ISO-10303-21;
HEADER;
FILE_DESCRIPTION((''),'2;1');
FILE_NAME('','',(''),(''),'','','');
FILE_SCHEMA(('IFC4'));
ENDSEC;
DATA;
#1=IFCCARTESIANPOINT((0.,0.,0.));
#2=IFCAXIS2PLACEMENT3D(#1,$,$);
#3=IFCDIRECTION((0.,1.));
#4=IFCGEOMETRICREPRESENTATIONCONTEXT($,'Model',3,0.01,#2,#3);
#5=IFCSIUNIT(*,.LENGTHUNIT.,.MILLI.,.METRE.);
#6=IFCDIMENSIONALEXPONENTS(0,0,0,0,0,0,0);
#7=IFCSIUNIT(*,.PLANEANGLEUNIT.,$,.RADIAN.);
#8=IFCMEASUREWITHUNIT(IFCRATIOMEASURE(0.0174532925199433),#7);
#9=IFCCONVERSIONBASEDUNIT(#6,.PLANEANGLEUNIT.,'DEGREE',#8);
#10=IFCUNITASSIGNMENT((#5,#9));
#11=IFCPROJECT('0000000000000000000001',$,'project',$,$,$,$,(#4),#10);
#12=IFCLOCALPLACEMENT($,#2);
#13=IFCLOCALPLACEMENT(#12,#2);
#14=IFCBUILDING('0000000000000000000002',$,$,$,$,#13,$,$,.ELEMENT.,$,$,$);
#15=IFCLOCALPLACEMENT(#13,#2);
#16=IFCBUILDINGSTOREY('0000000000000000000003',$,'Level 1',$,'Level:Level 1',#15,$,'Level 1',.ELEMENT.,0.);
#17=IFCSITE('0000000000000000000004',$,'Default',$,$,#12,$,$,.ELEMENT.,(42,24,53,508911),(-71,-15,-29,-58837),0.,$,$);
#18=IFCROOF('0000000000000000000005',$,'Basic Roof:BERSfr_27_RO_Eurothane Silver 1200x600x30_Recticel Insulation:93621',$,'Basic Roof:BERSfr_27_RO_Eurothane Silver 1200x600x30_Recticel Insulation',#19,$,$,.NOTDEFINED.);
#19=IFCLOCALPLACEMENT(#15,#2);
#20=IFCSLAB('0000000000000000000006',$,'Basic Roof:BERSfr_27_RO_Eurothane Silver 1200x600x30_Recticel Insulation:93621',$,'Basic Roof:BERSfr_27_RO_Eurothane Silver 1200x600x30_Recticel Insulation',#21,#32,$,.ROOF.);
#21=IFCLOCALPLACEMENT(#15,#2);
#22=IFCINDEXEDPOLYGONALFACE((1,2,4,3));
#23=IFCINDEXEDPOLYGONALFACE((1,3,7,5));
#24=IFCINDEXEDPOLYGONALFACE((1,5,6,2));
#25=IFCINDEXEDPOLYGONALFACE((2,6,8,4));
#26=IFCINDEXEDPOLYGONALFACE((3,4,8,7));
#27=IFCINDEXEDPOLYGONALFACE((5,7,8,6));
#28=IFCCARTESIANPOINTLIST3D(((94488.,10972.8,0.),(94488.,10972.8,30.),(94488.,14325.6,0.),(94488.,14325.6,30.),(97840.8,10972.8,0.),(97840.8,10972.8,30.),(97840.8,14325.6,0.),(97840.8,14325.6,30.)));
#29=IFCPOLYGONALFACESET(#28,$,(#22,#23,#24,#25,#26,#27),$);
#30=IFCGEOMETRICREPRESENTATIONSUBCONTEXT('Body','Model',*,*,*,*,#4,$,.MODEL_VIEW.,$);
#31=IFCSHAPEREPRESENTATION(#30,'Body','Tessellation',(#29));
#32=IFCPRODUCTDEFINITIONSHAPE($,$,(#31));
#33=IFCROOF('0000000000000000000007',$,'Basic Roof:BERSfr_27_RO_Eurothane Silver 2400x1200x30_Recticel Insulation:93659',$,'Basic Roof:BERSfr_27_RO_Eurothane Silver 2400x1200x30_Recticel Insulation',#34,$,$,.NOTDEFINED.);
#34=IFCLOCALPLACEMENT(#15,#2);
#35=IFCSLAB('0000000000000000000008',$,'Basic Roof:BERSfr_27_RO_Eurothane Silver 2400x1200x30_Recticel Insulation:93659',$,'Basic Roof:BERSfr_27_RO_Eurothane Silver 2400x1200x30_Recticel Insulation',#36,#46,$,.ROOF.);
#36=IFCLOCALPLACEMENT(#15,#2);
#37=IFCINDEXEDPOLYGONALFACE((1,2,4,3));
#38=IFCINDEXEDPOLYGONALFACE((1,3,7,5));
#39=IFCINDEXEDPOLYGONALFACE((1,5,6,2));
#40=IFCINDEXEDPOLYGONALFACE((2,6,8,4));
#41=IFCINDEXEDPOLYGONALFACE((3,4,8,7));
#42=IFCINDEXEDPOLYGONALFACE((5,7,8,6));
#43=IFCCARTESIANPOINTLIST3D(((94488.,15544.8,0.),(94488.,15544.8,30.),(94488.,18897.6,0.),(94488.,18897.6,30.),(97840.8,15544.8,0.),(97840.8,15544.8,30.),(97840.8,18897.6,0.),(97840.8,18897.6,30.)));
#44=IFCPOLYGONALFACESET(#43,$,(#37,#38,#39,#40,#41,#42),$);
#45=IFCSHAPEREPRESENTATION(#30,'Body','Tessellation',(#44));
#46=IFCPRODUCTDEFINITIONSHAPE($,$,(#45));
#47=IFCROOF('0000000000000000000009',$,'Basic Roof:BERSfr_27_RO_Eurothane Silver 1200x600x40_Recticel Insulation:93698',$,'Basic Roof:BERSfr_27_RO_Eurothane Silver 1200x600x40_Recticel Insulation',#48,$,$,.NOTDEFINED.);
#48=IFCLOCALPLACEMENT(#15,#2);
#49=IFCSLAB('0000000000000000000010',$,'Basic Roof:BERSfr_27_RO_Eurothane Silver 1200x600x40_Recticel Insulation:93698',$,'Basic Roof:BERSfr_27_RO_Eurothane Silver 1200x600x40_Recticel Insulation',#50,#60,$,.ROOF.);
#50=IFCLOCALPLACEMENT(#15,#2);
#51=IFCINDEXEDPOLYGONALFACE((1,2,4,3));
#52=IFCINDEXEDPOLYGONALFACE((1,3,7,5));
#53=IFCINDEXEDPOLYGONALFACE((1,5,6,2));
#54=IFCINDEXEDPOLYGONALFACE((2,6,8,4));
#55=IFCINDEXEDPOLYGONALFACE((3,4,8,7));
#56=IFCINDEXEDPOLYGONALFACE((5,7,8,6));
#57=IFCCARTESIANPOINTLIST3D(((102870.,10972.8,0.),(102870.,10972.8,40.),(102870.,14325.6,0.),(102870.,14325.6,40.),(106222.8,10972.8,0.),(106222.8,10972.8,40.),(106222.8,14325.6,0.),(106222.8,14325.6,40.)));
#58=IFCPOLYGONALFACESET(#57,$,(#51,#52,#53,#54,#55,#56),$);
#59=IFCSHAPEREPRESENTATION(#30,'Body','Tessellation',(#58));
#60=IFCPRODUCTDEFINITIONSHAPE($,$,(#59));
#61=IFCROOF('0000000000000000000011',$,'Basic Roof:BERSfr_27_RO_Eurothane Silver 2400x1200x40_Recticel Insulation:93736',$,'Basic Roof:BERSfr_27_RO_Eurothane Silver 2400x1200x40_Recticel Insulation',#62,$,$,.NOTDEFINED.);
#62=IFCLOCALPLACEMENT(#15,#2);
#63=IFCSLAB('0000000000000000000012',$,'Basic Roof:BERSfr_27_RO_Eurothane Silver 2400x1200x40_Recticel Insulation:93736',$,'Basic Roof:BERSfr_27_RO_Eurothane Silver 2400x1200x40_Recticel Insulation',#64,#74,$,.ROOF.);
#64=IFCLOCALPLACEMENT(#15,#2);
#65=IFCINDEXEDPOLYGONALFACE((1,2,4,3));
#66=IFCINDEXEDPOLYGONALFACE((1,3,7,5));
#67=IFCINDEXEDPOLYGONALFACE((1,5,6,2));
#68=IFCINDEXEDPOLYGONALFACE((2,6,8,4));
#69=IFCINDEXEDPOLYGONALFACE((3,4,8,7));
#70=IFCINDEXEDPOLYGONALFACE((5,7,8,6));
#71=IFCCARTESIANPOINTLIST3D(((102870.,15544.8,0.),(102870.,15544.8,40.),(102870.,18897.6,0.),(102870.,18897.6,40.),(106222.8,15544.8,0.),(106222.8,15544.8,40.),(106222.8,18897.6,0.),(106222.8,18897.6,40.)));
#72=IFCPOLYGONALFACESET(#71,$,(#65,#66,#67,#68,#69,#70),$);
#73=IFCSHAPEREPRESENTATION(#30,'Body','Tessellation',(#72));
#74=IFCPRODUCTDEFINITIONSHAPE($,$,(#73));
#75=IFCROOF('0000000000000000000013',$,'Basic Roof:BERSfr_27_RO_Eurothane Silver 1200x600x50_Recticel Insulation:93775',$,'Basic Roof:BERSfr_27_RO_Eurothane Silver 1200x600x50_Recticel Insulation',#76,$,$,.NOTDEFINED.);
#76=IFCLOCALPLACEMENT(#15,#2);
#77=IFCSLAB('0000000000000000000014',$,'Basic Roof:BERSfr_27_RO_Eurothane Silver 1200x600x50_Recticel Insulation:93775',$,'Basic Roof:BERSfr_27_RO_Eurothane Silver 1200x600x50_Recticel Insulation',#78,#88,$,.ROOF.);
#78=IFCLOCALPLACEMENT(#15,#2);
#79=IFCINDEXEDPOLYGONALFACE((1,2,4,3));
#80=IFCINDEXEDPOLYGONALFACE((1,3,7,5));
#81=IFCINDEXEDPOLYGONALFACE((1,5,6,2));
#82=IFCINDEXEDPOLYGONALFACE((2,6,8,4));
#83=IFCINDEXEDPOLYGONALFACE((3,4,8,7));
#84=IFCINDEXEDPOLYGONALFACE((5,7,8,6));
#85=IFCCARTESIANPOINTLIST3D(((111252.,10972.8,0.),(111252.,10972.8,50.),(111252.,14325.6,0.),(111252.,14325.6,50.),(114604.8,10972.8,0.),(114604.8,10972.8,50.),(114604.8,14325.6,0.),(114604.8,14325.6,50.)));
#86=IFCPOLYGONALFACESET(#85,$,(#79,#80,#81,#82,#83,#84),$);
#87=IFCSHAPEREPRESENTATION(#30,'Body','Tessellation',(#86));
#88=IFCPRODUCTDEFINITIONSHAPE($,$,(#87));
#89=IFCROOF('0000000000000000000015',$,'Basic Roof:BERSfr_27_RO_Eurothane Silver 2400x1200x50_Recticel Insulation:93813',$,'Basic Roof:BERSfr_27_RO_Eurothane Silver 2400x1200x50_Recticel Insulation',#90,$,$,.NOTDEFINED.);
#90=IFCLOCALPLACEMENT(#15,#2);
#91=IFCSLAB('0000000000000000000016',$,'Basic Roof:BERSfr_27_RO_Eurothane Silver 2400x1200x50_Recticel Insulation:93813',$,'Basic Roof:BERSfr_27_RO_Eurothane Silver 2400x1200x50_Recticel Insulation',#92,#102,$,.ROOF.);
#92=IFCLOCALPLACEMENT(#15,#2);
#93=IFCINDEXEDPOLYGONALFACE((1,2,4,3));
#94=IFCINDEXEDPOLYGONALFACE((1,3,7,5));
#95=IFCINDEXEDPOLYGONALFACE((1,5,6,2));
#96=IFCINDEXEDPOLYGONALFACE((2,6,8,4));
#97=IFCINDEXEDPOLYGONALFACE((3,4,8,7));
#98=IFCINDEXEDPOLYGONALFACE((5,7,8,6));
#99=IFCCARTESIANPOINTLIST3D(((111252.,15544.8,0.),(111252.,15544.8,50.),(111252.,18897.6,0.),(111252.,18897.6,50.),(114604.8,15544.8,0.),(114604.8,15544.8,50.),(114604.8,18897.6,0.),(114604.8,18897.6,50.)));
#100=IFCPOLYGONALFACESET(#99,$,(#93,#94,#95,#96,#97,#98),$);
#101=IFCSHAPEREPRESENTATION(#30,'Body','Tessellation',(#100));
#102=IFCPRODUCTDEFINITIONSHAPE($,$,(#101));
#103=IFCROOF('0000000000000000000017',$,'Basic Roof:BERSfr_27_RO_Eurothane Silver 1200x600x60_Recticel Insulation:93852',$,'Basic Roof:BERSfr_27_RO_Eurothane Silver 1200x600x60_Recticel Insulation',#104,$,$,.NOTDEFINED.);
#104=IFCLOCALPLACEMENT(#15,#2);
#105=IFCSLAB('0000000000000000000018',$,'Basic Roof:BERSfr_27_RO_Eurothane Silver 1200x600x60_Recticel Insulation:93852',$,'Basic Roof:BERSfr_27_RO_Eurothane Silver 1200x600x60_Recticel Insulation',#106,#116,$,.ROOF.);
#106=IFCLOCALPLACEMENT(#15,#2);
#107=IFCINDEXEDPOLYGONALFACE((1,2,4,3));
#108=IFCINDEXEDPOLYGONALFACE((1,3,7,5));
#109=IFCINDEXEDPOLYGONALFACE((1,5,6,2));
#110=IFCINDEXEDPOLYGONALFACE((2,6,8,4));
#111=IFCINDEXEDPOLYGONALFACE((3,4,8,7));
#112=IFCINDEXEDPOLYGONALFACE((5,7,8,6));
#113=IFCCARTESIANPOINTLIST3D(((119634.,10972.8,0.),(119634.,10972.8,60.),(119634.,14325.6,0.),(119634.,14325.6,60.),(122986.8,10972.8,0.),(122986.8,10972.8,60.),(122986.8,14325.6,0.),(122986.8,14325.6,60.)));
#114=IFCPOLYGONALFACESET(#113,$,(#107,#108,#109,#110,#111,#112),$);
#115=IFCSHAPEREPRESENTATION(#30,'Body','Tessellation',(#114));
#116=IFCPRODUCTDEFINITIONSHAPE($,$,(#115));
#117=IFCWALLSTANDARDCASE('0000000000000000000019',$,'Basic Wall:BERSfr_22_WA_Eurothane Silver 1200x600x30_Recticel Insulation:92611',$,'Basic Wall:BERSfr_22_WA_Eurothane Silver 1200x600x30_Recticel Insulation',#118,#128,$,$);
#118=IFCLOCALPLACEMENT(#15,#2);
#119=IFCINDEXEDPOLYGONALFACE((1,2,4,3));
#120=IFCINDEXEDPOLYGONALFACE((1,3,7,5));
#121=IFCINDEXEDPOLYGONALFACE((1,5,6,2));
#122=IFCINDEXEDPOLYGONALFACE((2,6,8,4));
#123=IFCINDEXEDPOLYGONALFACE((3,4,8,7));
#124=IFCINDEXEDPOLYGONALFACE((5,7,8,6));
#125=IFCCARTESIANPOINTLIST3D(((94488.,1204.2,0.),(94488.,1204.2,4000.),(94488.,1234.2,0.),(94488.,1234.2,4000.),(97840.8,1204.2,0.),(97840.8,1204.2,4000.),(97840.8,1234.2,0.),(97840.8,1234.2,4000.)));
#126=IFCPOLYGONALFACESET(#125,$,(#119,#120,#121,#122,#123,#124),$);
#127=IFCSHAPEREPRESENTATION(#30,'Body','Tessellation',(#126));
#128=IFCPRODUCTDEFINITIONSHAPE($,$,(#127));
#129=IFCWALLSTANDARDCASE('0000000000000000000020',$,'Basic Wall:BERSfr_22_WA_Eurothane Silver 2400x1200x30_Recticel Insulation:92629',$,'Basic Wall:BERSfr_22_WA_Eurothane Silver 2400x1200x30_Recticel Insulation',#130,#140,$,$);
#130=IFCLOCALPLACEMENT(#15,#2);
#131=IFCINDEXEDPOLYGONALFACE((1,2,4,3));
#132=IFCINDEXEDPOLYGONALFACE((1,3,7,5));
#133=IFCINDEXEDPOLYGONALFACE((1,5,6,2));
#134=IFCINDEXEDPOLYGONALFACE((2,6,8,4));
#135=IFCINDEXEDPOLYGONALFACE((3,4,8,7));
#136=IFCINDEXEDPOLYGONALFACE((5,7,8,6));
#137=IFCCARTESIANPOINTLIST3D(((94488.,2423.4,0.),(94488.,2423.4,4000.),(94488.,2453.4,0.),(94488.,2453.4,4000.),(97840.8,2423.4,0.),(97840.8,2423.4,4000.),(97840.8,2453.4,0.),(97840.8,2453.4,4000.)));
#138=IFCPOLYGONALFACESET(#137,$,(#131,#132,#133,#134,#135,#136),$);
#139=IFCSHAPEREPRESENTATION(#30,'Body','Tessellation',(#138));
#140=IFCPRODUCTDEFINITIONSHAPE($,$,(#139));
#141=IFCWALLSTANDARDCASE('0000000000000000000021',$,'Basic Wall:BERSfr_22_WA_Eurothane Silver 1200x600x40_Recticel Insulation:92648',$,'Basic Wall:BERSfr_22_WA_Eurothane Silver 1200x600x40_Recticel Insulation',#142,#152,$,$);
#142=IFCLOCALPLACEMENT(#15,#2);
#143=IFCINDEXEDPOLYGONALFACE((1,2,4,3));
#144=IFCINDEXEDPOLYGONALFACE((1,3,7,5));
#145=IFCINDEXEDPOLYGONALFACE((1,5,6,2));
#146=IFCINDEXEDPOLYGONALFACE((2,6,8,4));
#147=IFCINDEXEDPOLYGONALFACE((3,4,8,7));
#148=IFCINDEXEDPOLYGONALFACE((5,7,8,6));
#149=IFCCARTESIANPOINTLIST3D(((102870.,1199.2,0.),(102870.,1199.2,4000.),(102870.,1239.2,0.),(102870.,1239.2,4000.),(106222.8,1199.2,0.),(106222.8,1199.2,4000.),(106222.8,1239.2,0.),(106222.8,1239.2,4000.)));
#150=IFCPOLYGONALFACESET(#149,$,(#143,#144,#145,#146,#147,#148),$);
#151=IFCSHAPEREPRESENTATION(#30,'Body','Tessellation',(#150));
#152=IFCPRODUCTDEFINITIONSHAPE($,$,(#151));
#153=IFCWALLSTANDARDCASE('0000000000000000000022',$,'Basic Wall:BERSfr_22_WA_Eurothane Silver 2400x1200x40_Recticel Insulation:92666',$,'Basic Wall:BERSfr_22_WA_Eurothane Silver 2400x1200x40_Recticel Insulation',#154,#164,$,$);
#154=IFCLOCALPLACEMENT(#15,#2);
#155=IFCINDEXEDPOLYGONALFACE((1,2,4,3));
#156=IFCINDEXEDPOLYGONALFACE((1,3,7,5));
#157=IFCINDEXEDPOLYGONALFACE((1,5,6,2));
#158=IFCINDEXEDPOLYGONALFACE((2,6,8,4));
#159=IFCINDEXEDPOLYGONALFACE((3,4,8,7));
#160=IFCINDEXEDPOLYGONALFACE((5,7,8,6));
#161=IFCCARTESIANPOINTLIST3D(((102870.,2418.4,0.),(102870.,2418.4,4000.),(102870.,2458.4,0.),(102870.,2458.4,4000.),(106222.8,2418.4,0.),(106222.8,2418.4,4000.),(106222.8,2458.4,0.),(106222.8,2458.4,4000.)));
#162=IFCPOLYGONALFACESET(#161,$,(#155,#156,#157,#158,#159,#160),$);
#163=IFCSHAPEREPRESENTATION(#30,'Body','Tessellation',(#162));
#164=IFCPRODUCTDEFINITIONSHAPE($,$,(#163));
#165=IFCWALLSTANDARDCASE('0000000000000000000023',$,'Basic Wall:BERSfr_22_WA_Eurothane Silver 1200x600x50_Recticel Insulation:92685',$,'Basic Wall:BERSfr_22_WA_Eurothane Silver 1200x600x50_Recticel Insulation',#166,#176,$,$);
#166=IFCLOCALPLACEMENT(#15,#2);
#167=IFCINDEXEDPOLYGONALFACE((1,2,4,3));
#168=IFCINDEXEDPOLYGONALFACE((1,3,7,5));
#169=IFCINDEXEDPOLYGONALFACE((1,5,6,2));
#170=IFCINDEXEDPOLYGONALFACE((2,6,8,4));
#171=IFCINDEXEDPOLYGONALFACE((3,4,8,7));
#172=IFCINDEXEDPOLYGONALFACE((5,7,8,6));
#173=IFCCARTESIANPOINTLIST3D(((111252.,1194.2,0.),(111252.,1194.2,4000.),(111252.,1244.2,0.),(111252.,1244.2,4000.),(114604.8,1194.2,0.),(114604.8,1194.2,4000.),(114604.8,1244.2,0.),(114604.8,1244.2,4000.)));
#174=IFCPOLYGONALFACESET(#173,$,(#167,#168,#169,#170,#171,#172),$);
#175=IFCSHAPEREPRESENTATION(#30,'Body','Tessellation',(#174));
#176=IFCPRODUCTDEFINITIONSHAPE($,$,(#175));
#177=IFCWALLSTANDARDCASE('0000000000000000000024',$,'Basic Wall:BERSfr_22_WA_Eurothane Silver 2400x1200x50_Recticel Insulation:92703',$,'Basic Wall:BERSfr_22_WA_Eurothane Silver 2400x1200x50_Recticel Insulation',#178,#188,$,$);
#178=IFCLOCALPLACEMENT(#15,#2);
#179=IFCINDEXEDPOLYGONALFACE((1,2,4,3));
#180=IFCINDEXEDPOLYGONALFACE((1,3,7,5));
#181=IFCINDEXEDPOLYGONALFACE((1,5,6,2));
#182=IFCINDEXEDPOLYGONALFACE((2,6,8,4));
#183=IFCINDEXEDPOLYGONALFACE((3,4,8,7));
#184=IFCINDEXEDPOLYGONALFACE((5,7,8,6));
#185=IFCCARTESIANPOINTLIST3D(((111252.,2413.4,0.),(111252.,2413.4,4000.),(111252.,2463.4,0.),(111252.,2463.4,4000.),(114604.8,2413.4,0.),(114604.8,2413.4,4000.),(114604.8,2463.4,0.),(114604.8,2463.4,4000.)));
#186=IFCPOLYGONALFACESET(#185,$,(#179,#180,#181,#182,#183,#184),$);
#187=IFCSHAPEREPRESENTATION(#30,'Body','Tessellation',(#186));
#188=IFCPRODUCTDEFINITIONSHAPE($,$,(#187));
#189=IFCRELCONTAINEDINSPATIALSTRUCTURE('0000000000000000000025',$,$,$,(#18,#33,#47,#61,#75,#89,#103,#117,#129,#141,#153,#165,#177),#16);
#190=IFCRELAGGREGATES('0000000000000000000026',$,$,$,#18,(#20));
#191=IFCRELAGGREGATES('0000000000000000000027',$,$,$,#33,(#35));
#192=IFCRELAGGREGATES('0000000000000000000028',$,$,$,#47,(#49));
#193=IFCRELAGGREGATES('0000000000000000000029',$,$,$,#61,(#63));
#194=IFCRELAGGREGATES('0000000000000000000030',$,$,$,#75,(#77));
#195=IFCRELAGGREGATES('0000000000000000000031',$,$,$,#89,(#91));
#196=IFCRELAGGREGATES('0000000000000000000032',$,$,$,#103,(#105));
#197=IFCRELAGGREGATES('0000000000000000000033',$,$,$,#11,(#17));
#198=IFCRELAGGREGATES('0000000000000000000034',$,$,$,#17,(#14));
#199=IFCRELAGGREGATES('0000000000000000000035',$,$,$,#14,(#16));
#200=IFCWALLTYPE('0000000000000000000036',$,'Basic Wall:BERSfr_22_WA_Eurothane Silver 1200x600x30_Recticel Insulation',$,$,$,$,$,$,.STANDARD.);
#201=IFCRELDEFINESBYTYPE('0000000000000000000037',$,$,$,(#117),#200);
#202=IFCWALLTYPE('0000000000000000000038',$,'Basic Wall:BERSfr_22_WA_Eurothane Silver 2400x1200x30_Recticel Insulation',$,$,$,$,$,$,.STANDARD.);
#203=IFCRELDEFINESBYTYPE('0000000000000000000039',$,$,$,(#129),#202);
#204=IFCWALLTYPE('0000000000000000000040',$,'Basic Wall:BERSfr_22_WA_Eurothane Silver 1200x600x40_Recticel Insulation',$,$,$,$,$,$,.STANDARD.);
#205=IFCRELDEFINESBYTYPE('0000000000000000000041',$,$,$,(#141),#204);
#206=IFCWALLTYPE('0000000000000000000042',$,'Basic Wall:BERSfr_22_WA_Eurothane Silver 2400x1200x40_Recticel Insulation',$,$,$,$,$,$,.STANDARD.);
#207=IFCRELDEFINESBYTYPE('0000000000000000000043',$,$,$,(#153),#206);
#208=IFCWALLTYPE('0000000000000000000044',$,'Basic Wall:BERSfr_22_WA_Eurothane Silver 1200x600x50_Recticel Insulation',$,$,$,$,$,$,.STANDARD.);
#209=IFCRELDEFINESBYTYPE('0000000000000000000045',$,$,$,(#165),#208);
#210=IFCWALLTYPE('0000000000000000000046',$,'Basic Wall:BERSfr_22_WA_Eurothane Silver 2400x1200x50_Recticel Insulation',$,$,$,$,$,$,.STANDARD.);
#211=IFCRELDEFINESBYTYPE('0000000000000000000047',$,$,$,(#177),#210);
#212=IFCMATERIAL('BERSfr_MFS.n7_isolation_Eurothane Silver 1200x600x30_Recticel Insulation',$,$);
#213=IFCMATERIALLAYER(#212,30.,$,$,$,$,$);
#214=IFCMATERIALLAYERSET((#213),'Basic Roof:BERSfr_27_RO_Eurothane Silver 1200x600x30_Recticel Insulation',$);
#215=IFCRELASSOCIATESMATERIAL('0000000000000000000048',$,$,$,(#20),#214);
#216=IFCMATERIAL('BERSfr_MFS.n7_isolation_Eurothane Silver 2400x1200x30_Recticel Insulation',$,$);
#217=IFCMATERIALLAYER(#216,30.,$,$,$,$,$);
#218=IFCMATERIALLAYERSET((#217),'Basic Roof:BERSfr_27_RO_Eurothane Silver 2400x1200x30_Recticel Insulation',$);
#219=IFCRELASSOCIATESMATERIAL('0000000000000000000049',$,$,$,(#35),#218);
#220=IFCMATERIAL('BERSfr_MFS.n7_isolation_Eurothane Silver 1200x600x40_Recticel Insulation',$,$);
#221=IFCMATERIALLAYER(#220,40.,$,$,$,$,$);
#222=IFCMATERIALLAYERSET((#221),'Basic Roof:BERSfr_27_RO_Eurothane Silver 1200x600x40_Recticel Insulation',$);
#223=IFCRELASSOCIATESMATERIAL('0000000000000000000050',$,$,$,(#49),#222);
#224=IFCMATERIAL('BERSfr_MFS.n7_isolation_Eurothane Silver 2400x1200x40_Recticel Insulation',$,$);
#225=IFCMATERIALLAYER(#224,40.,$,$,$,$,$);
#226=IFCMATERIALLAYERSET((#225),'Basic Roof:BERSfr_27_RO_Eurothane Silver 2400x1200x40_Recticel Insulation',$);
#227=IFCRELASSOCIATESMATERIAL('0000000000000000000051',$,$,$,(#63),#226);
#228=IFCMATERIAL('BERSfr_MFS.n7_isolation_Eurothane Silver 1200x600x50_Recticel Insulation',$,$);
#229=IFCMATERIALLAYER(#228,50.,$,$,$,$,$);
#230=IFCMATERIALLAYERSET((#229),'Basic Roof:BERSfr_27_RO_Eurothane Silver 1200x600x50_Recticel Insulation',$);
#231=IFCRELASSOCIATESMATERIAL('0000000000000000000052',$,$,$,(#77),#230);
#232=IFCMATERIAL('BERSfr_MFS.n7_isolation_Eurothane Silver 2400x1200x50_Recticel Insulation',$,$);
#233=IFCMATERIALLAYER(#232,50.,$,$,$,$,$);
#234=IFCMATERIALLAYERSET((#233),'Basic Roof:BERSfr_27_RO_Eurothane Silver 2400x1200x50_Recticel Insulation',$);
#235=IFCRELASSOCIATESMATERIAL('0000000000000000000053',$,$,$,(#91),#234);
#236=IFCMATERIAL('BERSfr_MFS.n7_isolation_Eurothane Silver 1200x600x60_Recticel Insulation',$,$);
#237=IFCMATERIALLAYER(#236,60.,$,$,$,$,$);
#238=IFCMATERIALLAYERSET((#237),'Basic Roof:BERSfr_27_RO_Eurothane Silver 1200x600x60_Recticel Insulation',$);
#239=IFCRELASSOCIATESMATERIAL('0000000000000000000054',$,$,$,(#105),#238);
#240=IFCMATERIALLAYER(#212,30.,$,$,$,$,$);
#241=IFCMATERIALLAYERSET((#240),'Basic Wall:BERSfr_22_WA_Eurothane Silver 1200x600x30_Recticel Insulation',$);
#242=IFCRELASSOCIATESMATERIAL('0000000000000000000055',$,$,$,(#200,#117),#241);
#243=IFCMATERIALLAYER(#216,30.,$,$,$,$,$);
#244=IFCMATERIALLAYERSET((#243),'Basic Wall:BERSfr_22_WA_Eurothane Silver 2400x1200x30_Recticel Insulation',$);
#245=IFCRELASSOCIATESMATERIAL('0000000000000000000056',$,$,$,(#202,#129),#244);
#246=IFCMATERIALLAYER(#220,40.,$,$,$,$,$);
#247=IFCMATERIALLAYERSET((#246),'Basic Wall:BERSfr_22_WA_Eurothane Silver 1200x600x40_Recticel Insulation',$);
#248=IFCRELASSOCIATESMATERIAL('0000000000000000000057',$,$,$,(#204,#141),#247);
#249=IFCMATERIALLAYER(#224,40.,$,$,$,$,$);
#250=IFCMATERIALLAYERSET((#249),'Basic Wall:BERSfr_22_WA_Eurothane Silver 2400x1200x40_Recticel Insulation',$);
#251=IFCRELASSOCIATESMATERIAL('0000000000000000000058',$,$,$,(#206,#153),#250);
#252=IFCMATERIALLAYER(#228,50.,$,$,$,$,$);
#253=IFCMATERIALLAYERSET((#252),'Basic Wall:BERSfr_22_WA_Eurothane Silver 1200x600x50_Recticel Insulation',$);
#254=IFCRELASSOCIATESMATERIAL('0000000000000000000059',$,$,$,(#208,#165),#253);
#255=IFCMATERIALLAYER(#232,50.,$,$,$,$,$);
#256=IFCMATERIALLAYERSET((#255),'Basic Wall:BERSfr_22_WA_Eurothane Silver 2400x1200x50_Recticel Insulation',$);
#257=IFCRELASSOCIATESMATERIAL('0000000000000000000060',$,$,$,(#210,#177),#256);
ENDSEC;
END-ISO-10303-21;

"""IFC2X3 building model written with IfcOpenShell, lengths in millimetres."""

from ifc_helpers import new_model, entity, si_unit, converted_unit, direction, frame, frame_2d, origin, place, context, subcontext, project, spatial, rectangle, extrude, material, layer, layer_set, layer_usage, type_object, element, aggregate, save


model = new_model("IFC2X3")

# Units and contexts
model_context = context("Model", 3, precision=0.01, world=origin(), true_north=direction((0.0, 1.0)))
body_context = subcontext(model_context, "Body", "Model", "MODEL_VIEW")
ifc_project = project(units=[si_unit("LENGTHUNIT", "METRE", prefix="MILLI"), converted_unit("PLANEANGLEUNIT", "DEGREE", entity("IfcRatioMeasure", 0.0174532925199433), si_unit("PLANEANGLEUNIT", "RADIAN"), dimensions=[0, 0, 0, 0, 0, 0, 0])], contexts=[model_context])

# Site, building, storey
site_placement = place(None, origin())
site = spatial("IfcSite", under=ifc_project, at=site_placement, Name="Default", CompositionType="ELEMENT", RefLatitude=(42, 24, 53, 508911), RefLongitude=(-71, -15, -29, -58837), RefElevation=0.0)
building_placement = place(site_placement, origin())
building = spatial("IfcBuilding", under=site, at=building_placement, CompositionType="ELEMENT")
storey_placement = place(building_placement, origin())
storey = spatial("IfcBuildingStorey", under=building, at=storey_placement, Name="Level 1", ObjectType="Level:Level 1", LongName="Level 1", CompositionType="ELEMENT", Elevation=0.0)

# Roofs, slabs
roof_1_placement = place(storey_placement, frame((94488.0, 10972.8, 0.0)))
roof_1 = element("IfcRoof", 1, at=roof_1_placement, inside=storey, Name="Basic Roof:BERSfr_27_RO_Eurothane Silver 1200x600x30_Recticel Insulation:93621", ObjectType="Basic Roof:BERSfr_27_RO_Eurothane Silver 1200x600x30_Recticel Insulation", ShapeType="NOTDEFINED")
ifc_material_1 = material(Name="BERSfr_MFS.n7_isolation_Eurothane Silver 1200x600x30_Recticel Insulation")
ifc_layer_1 = layer(ifc_material_1, 30.0)
ifc_layer_set_1 = layer_set([ifc_layer_1], Name="Basic Roof:BERSfr_27_RO_Eurothane Silver 1200x600x30_Recticel Insulation")
slab_1_placement = place(roof_1_placement, origin())
slab_1 = element("IfcSlab", 2, at=slab_1_placement, material=ifc_layer_set_1, Name="Basic Roof:BERSfr_27_RO_Eurothane Silver 1200x600x30_Recticel Insulation:93621", ObjectType="Basic Roof:BERSfr_27_RO_Eurothane Silver 1200x600x30_Recticel Insulation", PredefinedType="ROOF", context=body_context, shape_type="SweptSolid", body=[
    extrude(rectangle(XDim=3352.8, YDim=3352.8, at=frame_2d((0.0, 0.0), x_axis=(-1.0, 0.0))), frame((1676.4, 1676.4, 0.0)), (0.0, 0.0, 1.0), 30.0),
])
aggregate(roof_1, [slab_1])
roof_2_placement = place(storey_placement, frame((94488.0, 15544.8, 0.0)))
roof_2 = element("IfcRoof", 3, at=roof_2_placement, inside=storey, Name="Basic Roof:BERSfr_27_RO_Eurothane Silver 2400x1200x30_Recticel Insulation:93659", ObjectType="Basic Roof:BERSfr_27_RO_Eurothane Silver 2400x1200x30_Recticel Insulation", ShapeType="NOTDEFINED")
ifc_material_2 = material(Name="BERSfr_MFS.n7_isolation_Eurothane Silver 2400x1200x30_Recticel Insulation")
ifc_layer_2 = layer(ifc_material_2, 30.0)
ifc_layer_set_2 = layer_set([ifc_layer_2], Name="Basic Roof:BERSfr_27_RO_Eurothane Silver 2400x1200x30_Recticel Insulation")
slab_2_placement = place(roof_2_placement, origin())
slab_2 = element("IfcSlab", 4, at=slab_2_placement, material=ifc_layer_set_2, Name="Basic Roof:BERSfr_27_RO_Eurothane Silver 2400x1200x30_Recticel Insulation:93659", ObjectType="Basic Roof:BERSfr_27_RO_Eurothane Silver 2400x1200x30_Recticel Insulation", PredefinedType="ROOF", context=body_context, shape_type="SweptSolid", body=[
    extrude(rectangle(XDim=3352.8, YDim=3352.8, at=frame_2d((0.0, 0.0), x_axis=(-1.0, 0.0))), frame((1676.4, 1676.4, 0.0)), (0.0, 0.0, 1.0), 30.0),
])
aggregate(roof_2, [slab_2])
roof_3_placement = place(storey_placement, frame((102870.0, 10972.8, 0.0)))
roof_3 = element("IfcRoof", 5, at=roof_3_placement, inside=storey, Name="Basic Roof:BERSfr_27_RO_Eurothane Silver 1200x600x40_Recticel Insulation:93698", ObjectType="Basic Roof:BERSfr_27_RO_Eurothane Silver 1200x600x40_Recticel Insulation", ShapeType="NOTDEFINED")
ifc_material_3 = material(Name="BERSfr_MFS.n7_isolation_Eurothane Silver 1200x600x40_Recticel Insulation")
ifc_layer_3 = layer(ifc_material_3, 40.0)
ifc_layer_set_3 = layer_set([ifc_layer_3], Name="Basic Roof:BERSfr_27_RO_Eurothane Silver 1200x600x40_Recticel Insulation")
slab_3_placement = place(roof_3_placement, origin())
slab_3 = element("IfcSlab", 6, at=slab_3_placement, material=ifc_layer_set_3, Name="Basic Roof:BERSfr_27_RO_Eurothane Silver 1200x600x40_Recticel Insulation:93698", ObjectType="Basic Roof:BERSfr_27_RO_Eurothane Silver 1200x600x40_Recticel Insulation", PredefinedType="ROOF", context=body_context, shape_type="SweptSolid", body=[
    extrude(rectangle(XDim=3352.8, YDim=3352.8, at=frame_2d((0.0, 0.0), x_axis=(-1.0, 0.0))), frame((1676.4, 1676.4, 0.0)), (0.0, 0.0, 1.0), 40.0),
])
aggregate(roof_3, [slab_3])
roof_4_placement = place(storey_placement, frame((102870.0, 15544.8, 0.0)))
roof_4 = element("IfcRoof", 7, at=roof_4_placement, inside=storey, Name="Basic Roof:BERSfr_27_RO_Eurothane Silver 2400x1200x40_Recticel Insulation:93736", ObjectType="Basic Roof:BERSfr_27_RO_Eurothane Silver 2400x1200x40_Recticel Insulation", ShapeType="NOTDEFINED")
ifc_material_4 = material(Name="BERSfr_MFS.n7_isolation_Eurothane Silver 2400x1200x40_Recticel Insulation")
ifc_layer_4 = layer(ifc_material_4, 40.0)
ifc_layer_set_4 = layer_set([ifc_layer_4], Name="Basic Roof:BERSfr_27_RO_Eurothane Silver 2400x1200x40_Recticel Insulation")
slab_4_placement = place(roof_4_placement, origin())
slab_4 = element("IfcSlab", 8, at=slab_4_placement, material=ifc_layer_set_4, Name="Basic Roof:BERSfr_27_RO_Eurothane Silver 2400x1200x40_Recticel Insulation:93736", ObjectType="Basic Roof:BERSfr_27_RO_Eurothane Silver 2400x1200x40_Recticel Insulation", PredefinedType="ROOF", context=body_context, shape_type="SweptSolid", body=[
    extrude(rectangle(XDim=3352.8, YDim=3352.8, at=frame_2d((0.0, 0.0), x_axis=(-1.0, 0.0))), frame((1676.4, 1676.4, 0.0)), (0.0, 0.0, 1.0), 40.0),
])
aggregate(roof_4, [slab_4])
roof_5_placement = place(storey_placement, frame((111252.0, 10972.8, 0.0)))
roof_5 = element("IfcRoof", 9, at=roof_5_placement, inside=storey, Name="Basic Roof:BERSfr_27_RO_Eurothane Silver 1200x600x50_Recticel Insulation:93775", ObjectType="Basic Roof:BERSfr_27_RO_Eurothane Silver 1200x600x50_Recticel Insulation", ShapeType="NOTDEFINED")
ifc_material_5 = material(Name="BERSfr_MFS.n7_isolation_Eurothane Silver 1200x600x50_Recticel Insulation")
ifc_layer_5 = layer(ifc_material_5, 50.0)
ifc_layer_set_5 = layer_set([ifc_layer_5], Name="Basic Roof:BERSfr_27_RO_Eurothane Silver 1200x600x50_Recticel Insulation")
slab_5_placement = place(roof_5_placement, origin())
slab_5 = element("IfcSlab", 10, at=slab_5_placement, material=ifc_layer_set_5, Name="Basic Roof:BERSfr_27_RO_Eurothane Silver 1200x600x50_Recticel Insulation:93775", ObjectType="Basic Roof:BERSfr_27_RO_Eurothane Silver 1200x600x50_Recticel Insulation", PredefinedType="ROOF", context=body_context, shape_type="SweptSolid", body=[
    extrude(rectangle(XDim=3352.8, YDim=3352.8, at=frame_2d((0.0, 0.0), x_axis=(-1.0, 0.0))), frame((1676.4, 1676.4, 0.0)), (0.0, 0.0, 1.0), 50.0),
])
aggregate(roof_5, [slab_5])
roof_6_placement = place(storey_placement, frame((111252.0, 15544.8, 0.0)))
roof_6 = element("IfcRoof", 11, at=roof_6_placement, inside=storey, Name="Basic Roof:BERSfr_27_RO_Eurothane Silver 2400x1200x50_Recticel Insulation:93813", ObjectType="Basic Roof:BERSfr_27_RO_Eurothane Silver 2400x1200x50_Recticel Insulation", ShapeType="NOTDEFINED")
ifc_material_6 = material(Name="BERSfr_MFS.n7_isolation_Eurothane Silver 2400x1200x50_Recticel Insulation")
ifc_layer_6 = layer(ifc_material_6, 50.0)
ifc_layer_set_6 = layer_set([ifc_layer_6], Name="Basic Roof:BERSfr_27_RO_Eurothane Silver 2400x1200x50_Recticel Insulation")
slab_6_placement = place(roof_6_placement, origin())
slab_6 = element("IfcSlab", 12, at=slab_6_placement, material=ifc_layer_set_6, Name="Basic Roof:BERSfr_27_RO_Eurothane Silver 2400x1200x50_Recticel Insulation:93813", ObjectType="Basic Roof:BERSfr_27_RO_Eurothane Silver 2400x1200x50_Recticel Insulation", PredefinedType="ROOF", context=body_context, shape_type="SweptSolid", body=[
    extrude(rectangle(XDim=3352.8, YDim=3352.8, at=frame_2d((0.0, 0.0), x_axis=(-1.0, 0.0))), frame((1676.4, 1676.4, 0.0)), (0.0, 0.0, 1.0), 50.0),
])
aggregate(roof_6, [slab_6])
roof_7_placement = place(storey_placement, frame((119634.0, 10972.8, 0.0)))
roof_7 = element("IfcRoof", 13, at=roof_7_placement, inside=storey, Name="Basic Roof:BERSfr_27_RO_Eurothane Silver 1200x600x60_Recticel Insulation:93852", ObjectType="Basic Roof:BERSfr_27_RO_Eurothane Silver 1200x600x60_Recticel Insulation", ShapeType="NOTDEFINED")
ifc_material_7 = material(Name="BERSfr_MFS.n7_isolation_Eurothane Silver 1200x600x60_Recticel Insulation")
ifc_layer_7 = layer(ifc_material_7, 60.0)
ifc_layer_set_7 = layer_set([ifc_layer_7], Name="Basic Roof:BERSfr_27_RO_Eurothane Silver 1200x600x60_Recticel Insulation")
slab_7_placement = place(roof_7_placement, origin())
slab_7 = element("IfcSlab", 14, at=slab_7_placement, material=ifc_layer_set_7, Name="Basic Roof:BERSfr_27_RO_Eurothane Silver 1200x600x60_Recticel Insulation:93852", ObjectType="Basic Roof:BERSfr_27_RO_Eurothane Silver 1200x600x60_Recticel Insulation", PredefinedType="ROOF", context=body_context, shape_type="SweptSolid", body=[
    extrude(rectangle(XDim=3352.8, YDim=3352.8, at=frame_2d((0.0, 0.0), x_axis=(-1.0, 0.0))), frame((1676.4, 1676.4, 0.0)), (0.0, 0.0, 1.0), 60.0),
])
aggregate(roof_7, [slab_7])

# Walls
ifc_layer_8 = layer(ifc_material_1, 30.0)
ifc_layer_set_8 = layer_set([ifc_layer_8], Name="Basic Wall:BERSfr_22_WA_Eurothane Silver 1200x600x30_Recticel Insulation")
ifc_layer_usage_1 = layer_usage(ifc_layer_set_8, "AXIS2", "NEGATIVE", 15.0)
wall_type_1 = type_object("IfcWallType", Name="Basic Wall:BERSfr_22_WA_Eurothane Silver 1200x600x30_Recticel Insulation", PredefinedType="STANDARD", material=ifc_layer_set_8)
wall_1_placement = place(storey_placement, frame((94488.0, 1219.2, 0.0)))
element("IfcWallStandardCase", 15, at=wall_1_placement, inside=storey, type_object=wall_type_1, material=ifc_layer_usage_1, Name="Basic Wall:BERSfr_22_WA_Eurothane Silver 1200x600x30_Recticel Insulation:92611", ObjectType="Basic Wall:BERSfr_22_WA_Eurothane Silver 1200x600x30_Recticel Insulation", context=body_context, shape_type="SweptSolid", body=[
    extrude(rectangle(XDim=3352.8, YDim=30.0, at=frame_2d((1676.4, 0.0), x_axis=(-1.0, 0.0))), origin(), (0.0, 0.0, 1.0), 4000.0),
])
ifc_layer_9 = layer(ifc_material_2, 30.0)
ifc_layer_set_9 = layer_set([ifc_layer_9], Name="Basic Wall:BERSfr_22_WA_Eurothane Silver 2400x1200x30_Recticel Insulation")
ifc_layer_usage_2 = layer_usage(ifc_layer_set_9, "AXIS2", "NEGATIVE", 15.0)
wall_type_2 = type_object("IfcWallType", Name="Basic Wall:BERSfr_22_WA_Eurothane Silver 2400x1200x30_Recticel Insulation", PredefinedType="STANDARD", material=ifc_layer_set_9)
wall_2_placement = place(storey_placement, frame((94488.0, 2438.4, 0.0)))
element("IfcWallStandardCase", 16, at=wall_2_placement, inside=storey, type_object=wall_type_2, material=ifc_layer_usage_2, Name="Basic Wall:BERSfr_22_WA_Eurothane Silver 2400x1200x30_Recticel Insulation:92629", ObjectType="Basic Wall:BERSfr_22_WA_Eurothane Silver 2400x1200x30_Recticel Insulation", context=body_context, shape_type="SweptSolid", body=[
    extrude(rectangle(XDim=3352.8, YDim=30.0, at=frame_2d((1676.4, 0.0), x_axis=(-1.0, 0.0))), origin(), (0.0, 0.0, 1.0), 4000.0),
])
ifc_layer_10 = layer(ifc_material_3, 40.0)
ifc_layer_set_10 = layer_set([ifc_layer_10], Name="Basic Wall:BERSfr_22_WA_Eurothane Silver 1200x600x40_Recticel Insulation")
ifc_layer_usage_3 = layer_usage(ifc_layer_set_10, "AXIS2", "NEGATIVE", 20.0)
wall_type_3 = type_object("IfcWallType", Name="Basic Wall:BERSfr_22_WA_Eurothane Silver 1200x600x40_Recticel Insulation", PredefinedType="STANDARD", material=ifc_layer_set_10)
wall_3_placement = place(storey_placement, frame((102870.0, 1219.2, 0.0)))
element("IfcWallStandardCase", 17, at=wall_3_placement, inside=storey, type_object=wall_type_3, material=ifc_layer_usage_3, Name="Basic Wall:BERSfr_22_WA_Eurothane Silver 1200x600x40_Recticel Insulation:92648", ObjectType="Basic Wall:BERSfr_22_WA_Eurothane Silver 1200x600x40_Recticel Insulation", context=body_context, shape_type="SweptSolid", body=[
    extrude(rectangle(XDim=3352.8, YDim=40.0, at=frame_2d((1676.4, 0.0), x_axis=(-1.0, 0.0))), origin(), (0.0, 0.0, 1.0), 4000.0),
])
ifc_layer_11 = layer(ifc_material_4, 40.0)
ifc_layer_set_11 = layer_set([ifc_layer_11], Name="Basic Wall:BERSfr_22_WA_Eurothane Silver 2400x1200x40_Recticel Insulation")
ifc_layer_usage_4 = layer_usage(ifc_layer_set_11, "AXIS2", "NEGATIVE", 20.0)
wall_type_4 = type_object("IfcWallType", Name="Basic Wall:BERSfr_22_WA_Eurothane Silver 2400x1200x40_Recticel Insulation", PredefinedType="STANDARD", material=ifc_layer_set_11)
wall_4_placement = place(storey_placement, frame((102870.0, 2438.4, 0.0)))
element("IfcWallStandardCase", 18, at=wall_4_placement, inside=storey, type_object=wall_type_4, material=ifc_layer_usage_4, Name="Basic Wall:BERSfr_22_WA_Eurothane Silver 2400x1200x40_Recticel Insulation:92666", ObjectType="Basic Wall:BERSfr_22_WA_Eurothane Silver 2400x1200x40_Recticel Insulation", context=body_context, shape_type="SweptSolid", body=[
    extrude(rectangle(XDim=3352.8, YDim=40.0, at=frame_2d((1676.4, 0.0), x_axis=(-1.0, 0.0))), origin(), (0.0, 0.0, 1.0), 4000.0),
])
ifc_layer_12 = layer(ifc_material_5, 50.0)
ifc_layer_set_12 = layer_set([ifc_layer_12], Name="Basic Wall:BERSfr_22_WA_Eurothane Silver 1200x600x50_Recticel Insulation")
ifc_layer_usage_5 = layer_usage(ifc_layer_set_12, "AXIS2", "NEGATIVE", 25.0)
wall_type_5 = type_object("IfcWallType", Name="Basic Wall:BERSfr_22_WA_Eurothane Silver 1200x600x50_Recticel Insulation", PredefinedType="STANDARD", material=ifc_layer_set_12)
wall_5_placement = place(storey_placement, frame((111252.0, 1219.2, 0.0)))
element("IfcWallStandardCase", 19, at=wall_5_placement, inside=storey, type_object=wall_type_5, material=ifc_layer_usage_5, Name="Basic Wall:BERSfr_22_WA_Eurothane Silver 1200x600x50_Recticel Insulation:92685", ObjectType="Basic Wall:BERSfr_22_WA_Eurothane Silver 1200x600x50_Recticel Insulation", context=body_context, shape_type="SweptSolid", body=[
    extrude(rectangle(XDim=3352.8, YDim=50.0, at=frame_2d((1676.4, 0.0), x_axis=(-1.0, 0.0))), origin(), (0.0, 0.0, 1.0), 4000.0),
])
ifc_layer_13 = layer(ifc_material_6, 50.0)
ifc_layer_set_13 = layer_set([ifc_layer_13], Name="Basic Wall:BERSfr_22_WA_Eurothane Silver 2400x1200x50_Recticel Insulation")
ifc_layer_usage_6 = layer_usage(ifc_layer_set_13, "AXIS2", "NEGATIVE", 25.0)
wall_type_6 = type_object("IfcWallType", Name="Basic Wall:BERSfr_22_WA_Eurothane Silver 2400x1200x50_Recticel Insulation", PredefinedType="STANDARD", material=ifc_layer_set_13)
wall_6_placement = place(storey_placement, frame((111252.0, 2438.4, 0.0)))
element("IfcWallStandardCase", 20, at=wall_6_placement, inside=storey, type_object=wall_type_6, material=ifc_layer_usage_6, Name="Basic Wall:BERSfr_22_WA_Eurothane Silver 2400x1200x50_Recticel Insulation:92703", ObjectType="Basic Wall:BERSfr_22_WA_Eurothane Silver 2400x1200x50_Recticel Insulation", context=body_context, shape_type="SweptSolid", body=[
    extrude(rectangle(XDim=3352.8, YDim=50.0, at=frame_2d((1676.4, 0.0), x_axis=(-1.0, 0.0))), origin(), (0.0, 0.0, 1.0), 4000.0),
])

save(model, "model.ifc")
